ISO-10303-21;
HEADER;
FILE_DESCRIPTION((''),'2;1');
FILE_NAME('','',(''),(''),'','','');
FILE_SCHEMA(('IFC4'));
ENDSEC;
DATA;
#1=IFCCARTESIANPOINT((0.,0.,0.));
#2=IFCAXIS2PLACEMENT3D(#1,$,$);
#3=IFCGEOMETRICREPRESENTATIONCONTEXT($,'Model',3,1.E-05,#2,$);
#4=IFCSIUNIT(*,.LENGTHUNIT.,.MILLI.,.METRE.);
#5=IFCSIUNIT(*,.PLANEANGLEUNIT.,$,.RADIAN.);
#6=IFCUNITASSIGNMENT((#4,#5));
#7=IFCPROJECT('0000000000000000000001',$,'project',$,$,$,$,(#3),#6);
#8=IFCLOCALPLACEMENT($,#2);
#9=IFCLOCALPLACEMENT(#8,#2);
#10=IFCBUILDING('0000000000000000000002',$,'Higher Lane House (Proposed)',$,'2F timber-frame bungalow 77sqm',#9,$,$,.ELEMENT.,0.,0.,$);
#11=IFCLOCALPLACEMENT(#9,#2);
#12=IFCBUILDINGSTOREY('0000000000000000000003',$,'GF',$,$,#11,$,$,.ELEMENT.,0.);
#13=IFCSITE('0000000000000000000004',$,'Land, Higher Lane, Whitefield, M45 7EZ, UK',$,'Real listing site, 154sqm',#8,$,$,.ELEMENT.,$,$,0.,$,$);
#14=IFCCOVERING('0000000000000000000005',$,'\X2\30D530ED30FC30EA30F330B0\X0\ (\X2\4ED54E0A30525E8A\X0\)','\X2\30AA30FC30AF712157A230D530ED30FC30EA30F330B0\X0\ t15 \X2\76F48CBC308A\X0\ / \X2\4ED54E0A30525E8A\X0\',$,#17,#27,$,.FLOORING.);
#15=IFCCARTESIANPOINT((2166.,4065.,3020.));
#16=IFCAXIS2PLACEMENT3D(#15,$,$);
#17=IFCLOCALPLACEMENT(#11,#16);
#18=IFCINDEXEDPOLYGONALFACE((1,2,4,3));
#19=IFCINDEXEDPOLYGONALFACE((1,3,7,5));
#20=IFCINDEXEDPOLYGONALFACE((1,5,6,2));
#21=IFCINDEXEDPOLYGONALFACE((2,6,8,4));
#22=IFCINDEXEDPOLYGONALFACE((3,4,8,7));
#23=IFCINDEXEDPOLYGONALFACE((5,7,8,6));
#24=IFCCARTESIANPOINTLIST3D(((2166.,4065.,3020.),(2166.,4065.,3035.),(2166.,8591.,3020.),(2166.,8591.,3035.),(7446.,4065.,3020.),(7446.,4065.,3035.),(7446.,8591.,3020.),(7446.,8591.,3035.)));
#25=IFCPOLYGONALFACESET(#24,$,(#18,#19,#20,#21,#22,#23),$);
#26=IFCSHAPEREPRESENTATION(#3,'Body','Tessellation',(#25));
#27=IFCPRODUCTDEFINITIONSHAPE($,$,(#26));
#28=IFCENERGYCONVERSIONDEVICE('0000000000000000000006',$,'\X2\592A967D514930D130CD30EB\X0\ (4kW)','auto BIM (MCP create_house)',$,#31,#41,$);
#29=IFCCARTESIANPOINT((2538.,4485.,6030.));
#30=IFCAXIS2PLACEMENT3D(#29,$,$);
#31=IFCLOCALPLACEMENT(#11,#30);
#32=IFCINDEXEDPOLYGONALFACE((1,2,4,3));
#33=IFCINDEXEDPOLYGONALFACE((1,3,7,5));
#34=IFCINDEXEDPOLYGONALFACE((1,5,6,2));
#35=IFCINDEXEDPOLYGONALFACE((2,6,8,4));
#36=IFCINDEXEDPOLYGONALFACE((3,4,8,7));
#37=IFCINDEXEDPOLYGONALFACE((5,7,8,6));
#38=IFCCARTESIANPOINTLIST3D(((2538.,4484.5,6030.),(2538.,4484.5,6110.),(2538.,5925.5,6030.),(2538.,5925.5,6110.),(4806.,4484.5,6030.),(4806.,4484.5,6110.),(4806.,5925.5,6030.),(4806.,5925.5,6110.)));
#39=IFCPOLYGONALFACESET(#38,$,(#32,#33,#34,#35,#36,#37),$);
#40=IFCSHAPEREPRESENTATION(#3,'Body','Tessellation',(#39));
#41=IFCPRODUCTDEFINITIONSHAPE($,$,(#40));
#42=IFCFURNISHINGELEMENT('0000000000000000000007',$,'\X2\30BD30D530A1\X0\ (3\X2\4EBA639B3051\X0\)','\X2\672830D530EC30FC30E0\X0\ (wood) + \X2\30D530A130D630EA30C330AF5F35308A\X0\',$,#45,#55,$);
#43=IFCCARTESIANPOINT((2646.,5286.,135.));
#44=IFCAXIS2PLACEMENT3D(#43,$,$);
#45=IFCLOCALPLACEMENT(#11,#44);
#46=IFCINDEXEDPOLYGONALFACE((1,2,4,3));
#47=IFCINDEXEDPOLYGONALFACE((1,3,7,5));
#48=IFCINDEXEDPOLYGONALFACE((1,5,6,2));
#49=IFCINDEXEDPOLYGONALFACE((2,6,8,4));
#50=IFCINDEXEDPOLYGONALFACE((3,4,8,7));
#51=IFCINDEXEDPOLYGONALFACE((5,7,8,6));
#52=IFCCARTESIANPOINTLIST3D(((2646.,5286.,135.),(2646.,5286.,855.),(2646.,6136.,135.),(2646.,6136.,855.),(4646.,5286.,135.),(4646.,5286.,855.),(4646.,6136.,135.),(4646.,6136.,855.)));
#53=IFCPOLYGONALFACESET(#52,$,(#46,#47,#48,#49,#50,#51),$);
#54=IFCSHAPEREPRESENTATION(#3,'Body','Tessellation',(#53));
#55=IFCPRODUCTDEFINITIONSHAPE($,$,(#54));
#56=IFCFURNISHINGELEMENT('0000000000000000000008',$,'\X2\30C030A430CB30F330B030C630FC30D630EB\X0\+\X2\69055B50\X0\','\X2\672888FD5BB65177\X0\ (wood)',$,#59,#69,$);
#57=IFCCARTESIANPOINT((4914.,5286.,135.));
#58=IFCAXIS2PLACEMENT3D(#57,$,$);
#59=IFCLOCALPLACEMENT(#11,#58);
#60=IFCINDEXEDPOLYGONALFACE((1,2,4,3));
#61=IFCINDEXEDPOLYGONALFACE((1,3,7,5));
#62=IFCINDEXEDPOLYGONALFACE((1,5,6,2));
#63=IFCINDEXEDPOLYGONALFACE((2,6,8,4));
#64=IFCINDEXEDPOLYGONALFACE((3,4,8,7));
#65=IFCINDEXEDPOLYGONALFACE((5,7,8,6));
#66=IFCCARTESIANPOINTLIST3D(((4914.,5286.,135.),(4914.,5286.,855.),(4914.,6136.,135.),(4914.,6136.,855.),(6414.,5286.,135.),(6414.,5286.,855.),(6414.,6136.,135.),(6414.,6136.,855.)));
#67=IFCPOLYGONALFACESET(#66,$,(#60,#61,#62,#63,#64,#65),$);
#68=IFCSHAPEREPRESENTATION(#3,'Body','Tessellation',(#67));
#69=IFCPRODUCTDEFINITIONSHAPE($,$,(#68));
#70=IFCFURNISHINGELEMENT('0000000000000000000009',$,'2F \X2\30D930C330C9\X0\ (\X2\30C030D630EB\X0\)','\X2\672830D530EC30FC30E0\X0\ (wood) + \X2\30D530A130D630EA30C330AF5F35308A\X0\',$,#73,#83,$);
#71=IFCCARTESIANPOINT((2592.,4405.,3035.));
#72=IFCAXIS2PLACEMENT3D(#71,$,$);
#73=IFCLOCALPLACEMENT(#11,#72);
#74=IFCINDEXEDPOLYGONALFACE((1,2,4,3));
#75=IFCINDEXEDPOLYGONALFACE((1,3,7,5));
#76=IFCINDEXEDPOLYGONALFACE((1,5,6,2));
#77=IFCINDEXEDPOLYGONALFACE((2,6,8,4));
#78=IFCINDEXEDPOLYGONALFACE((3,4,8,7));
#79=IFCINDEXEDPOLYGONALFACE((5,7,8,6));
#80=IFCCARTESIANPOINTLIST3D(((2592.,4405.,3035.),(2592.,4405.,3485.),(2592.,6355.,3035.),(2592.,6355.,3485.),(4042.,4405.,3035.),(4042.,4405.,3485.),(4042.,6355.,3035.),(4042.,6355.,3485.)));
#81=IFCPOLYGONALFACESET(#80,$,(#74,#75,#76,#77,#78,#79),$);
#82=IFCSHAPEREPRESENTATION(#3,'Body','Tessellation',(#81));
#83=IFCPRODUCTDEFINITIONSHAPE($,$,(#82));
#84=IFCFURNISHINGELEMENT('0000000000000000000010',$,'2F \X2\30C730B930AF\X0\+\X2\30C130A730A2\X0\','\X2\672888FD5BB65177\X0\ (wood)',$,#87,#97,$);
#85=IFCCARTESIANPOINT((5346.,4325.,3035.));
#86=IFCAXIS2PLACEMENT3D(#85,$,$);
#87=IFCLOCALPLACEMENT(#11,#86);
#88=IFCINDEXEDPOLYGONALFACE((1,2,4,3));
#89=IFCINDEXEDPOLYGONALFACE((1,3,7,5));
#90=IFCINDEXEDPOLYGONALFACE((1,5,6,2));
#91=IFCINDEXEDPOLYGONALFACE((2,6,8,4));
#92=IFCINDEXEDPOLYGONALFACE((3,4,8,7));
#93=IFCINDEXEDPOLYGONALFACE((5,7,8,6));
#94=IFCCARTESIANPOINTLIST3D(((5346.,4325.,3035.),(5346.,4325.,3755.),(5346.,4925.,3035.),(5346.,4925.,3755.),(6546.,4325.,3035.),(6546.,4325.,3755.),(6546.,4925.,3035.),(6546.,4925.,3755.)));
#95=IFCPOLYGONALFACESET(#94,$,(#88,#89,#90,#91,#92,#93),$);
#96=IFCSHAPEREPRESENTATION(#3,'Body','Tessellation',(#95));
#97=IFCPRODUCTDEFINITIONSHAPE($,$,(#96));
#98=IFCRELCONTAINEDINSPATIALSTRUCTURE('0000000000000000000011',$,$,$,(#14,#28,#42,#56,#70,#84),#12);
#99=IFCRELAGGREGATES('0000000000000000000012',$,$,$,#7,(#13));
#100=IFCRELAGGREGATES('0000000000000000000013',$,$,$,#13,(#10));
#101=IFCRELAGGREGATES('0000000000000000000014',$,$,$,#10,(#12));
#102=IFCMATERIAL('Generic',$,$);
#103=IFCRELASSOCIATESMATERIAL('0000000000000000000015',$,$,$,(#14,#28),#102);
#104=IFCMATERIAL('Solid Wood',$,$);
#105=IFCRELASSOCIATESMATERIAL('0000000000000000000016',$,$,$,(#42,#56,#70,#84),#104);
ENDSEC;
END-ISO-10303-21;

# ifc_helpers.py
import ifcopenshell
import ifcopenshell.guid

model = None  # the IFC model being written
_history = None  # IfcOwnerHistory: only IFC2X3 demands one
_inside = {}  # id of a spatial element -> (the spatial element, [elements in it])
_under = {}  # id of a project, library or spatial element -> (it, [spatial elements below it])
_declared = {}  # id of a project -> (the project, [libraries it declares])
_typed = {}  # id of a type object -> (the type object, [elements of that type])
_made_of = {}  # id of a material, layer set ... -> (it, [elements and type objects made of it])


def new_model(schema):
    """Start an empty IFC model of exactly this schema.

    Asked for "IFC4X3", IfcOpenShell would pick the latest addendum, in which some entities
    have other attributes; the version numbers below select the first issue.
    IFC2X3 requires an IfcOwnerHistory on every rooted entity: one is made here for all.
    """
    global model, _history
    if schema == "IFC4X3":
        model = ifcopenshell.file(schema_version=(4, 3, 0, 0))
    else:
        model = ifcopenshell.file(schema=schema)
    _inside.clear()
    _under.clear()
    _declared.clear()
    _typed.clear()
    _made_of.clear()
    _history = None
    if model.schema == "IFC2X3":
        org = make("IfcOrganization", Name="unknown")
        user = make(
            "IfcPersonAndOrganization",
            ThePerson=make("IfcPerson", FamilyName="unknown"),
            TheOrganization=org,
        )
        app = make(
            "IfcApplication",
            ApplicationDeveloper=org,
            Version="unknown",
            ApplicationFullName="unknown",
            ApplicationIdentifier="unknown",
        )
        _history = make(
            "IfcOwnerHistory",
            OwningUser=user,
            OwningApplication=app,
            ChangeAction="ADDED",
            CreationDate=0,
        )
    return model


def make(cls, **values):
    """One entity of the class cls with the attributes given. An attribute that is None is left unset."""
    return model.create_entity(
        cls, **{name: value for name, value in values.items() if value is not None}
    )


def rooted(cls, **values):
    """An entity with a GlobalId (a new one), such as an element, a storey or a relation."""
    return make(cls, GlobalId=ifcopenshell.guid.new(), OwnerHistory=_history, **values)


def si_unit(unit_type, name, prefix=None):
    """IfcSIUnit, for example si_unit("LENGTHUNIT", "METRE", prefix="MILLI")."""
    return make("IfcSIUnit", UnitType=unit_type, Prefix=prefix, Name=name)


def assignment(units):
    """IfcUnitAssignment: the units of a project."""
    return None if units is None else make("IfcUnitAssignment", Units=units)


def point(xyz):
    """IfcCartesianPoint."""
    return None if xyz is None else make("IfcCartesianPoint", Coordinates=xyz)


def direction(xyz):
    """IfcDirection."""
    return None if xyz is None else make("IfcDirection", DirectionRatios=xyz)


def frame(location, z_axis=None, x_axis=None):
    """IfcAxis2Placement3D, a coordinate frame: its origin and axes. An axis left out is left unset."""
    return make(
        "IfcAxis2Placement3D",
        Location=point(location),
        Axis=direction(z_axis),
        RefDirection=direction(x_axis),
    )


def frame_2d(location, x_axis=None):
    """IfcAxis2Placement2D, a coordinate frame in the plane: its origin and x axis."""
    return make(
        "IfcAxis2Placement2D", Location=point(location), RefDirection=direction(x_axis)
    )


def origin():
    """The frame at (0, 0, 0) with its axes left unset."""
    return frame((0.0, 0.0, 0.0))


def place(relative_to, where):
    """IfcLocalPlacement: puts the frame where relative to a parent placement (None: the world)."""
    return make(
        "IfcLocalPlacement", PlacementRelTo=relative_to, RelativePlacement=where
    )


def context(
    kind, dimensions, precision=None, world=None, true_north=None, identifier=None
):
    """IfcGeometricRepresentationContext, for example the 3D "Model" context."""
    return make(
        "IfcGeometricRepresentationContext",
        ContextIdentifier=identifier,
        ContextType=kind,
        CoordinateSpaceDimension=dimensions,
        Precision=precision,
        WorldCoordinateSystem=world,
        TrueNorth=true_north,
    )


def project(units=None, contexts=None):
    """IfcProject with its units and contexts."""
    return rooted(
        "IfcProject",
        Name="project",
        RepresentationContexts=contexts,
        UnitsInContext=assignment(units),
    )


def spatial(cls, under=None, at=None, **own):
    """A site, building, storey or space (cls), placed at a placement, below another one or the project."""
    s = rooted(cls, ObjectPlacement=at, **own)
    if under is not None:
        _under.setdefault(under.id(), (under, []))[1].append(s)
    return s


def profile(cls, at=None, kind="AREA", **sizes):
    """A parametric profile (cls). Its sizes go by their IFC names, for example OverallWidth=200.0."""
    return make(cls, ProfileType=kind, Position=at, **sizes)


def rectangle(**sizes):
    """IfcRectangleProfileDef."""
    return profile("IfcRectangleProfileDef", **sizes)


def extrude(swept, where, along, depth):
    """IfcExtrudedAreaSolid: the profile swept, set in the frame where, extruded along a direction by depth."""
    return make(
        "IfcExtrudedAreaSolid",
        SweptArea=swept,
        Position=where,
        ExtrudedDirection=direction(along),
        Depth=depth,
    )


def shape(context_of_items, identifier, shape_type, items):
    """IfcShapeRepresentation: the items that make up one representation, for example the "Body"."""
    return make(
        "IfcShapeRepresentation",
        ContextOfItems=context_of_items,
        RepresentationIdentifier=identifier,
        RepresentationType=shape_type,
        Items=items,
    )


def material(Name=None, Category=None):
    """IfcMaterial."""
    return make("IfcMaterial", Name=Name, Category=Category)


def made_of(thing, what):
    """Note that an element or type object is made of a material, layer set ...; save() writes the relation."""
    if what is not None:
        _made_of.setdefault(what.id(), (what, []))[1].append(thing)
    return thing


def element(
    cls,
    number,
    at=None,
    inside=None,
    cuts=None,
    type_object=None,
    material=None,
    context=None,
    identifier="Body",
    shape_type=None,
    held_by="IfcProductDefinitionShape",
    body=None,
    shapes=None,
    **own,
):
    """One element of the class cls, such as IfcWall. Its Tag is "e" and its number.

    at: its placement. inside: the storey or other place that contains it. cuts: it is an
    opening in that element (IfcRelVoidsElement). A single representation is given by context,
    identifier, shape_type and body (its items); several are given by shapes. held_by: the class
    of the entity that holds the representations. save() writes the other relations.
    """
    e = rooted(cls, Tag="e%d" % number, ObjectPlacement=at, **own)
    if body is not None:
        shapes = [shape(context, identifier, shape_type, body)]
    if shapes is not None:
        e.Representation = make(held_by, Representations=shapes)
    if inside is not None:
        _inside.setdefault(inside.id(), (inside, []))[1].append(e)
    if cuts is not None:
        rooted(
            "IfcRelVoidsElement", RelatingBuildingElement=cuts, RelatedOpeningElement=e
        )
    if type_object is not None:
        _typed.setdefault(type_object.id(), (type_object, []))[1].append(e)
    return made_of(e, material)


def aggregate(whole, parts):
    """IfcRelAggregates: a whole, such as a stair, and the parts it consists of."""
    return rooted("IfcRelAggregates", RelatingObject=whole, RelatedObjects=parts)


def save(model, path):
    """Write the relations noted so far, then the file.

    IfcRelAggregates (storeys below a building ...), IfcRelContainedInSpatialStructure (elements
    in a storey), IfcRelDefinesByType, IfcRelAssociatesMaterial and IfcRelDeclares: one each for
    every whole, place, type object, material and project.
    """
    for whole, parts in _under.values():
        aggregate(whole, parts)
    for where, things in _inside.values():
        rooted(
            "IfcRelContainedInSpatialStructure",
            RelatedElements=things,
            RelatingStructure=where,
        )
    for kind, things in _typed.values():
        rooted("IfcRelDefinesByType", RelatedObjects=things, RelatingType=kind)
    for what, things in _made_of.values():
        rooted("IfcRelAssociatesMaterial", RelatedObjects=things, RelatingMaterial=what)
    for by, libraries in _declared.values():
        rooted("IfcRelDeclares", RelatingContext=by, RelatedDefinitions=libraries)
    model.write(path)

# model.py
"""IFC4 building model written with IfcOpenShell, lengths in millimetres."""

from ifc_helpers import new_model, si_unit, frame, frame_2d, origin, place, context, project, spatial, rectangle, extrude, material, element, save


model = new_model("IFC4")

# Units and contexts
model_context = context("Model", 3, precision=1e-05, world=origin())
ifc_project = project(units=[si_unit("LENGTHUNIT", "METRE", prefix="MILLI"), si_unit("PLANEANGLEUNIT", "RADIAN")], contexts=[model_context])

# Site, building, storey
site_placement = place(None, origin())
site = spatial("IfcSite", under=ifc_project, at=site_placement, Name="Land, Higher Lane, Whitefield, M45 7EZ, UK", ObjectType="Real listing site, 154sqm", CompositionType="ELEMENT", RefElevation=0.0)
building_placement = place(site_placement, origin())
building = spatial("IfcBuilding", under=site, at=building_placement, Name="Higher Lane House (Proposed)", ObjectType="2F timber-frame bungalow 77sqm", CompositionType="ELEMENT", ElevationOfRefHeight=0.0, ElevationOfTerrain=0.0)
storey_placement = place(building_placement, origin())
storey = spatial("IfcBuildingStorey", under=building, at=storey_placement, Name="GF", CompositionType="ELEMENT", Elevation=0.0)

# Shared definitions
ifc_material_1 = material(Name="Solid Wood")

# Covering
ifc_material_2 = material(Name="Generic")
covering_placement = place(storey_placement, frame((2166.0, 4065.0, 3020.0)))
element("IfcCovering", 1, at=covering_placement, inside=storey, material=ifc_material_2, Name="フローリング (仕上げ床)", Description="オーク無垢フローリング t15 直貼り / 仕上げ床", PredefinedType="FLOORING", context=model_context, shape_type="SweptSolid", body=[
    extrude(rectangle(XDim=5280.0, YDim=4526.0, at=frame_2d((2640.0, 2263.0))), frame((2166.0, 4065.0, 3020.0)), (0.0, 0.0, 1.0), 15.0),
])

# Energy conversion device
energy_conversion_device_placement = place(storey_placement, frame((2538.0, 4485.0, 6030.0)))
element("IfcEnergyConversionDevice", 2, at=energy_conversion_device_placement, inside=storey, material=ifc_material_2, Name="太陽光パネル (4kW)", Description="auto BIM (MCP create_house)", context=model_context, shape_type="SweptSolid", body=[
    extrude(rectangle(XDim=2268.0, YDim=1441.0, at=frame_2d((1134.0, 720.0))), frame((2538.0, 4485.0, 6030.0)), (0.0, 0.0, 1.0), 80.0),
])

# Furnishing elements
furnishing_1_placement = place(storey_placement, frame((2646.0, 5286.0, 135.0)))
element("IfcFurnishingElement", 3, at=furnishing_1_placement, inside=storey, material=ifc_material_1, Name="ソファ (3人掛け)", Description="木フレーム (wood) + ファブリック張り", context=model_context, shape_type="SweptSolid", body=[
    extrude(rectangle(XDim=2000.0, YDim=850.0, at=frame_2d((1000.0, 425.0))), frame((2646.0, 5286.0, 135.0)), (0.0, 0.0, 1.0), 720.0),
])
furnishing_2_placement = place(storey_placement, frame((4914.0, 5286.0, 135.0)))
element("IfcFurnishingElement", 4, at=furnishing_2_placement, inside=storey, material=ifc_material_1, Name="ダイニングテーブル+椅子", Description="木製家具 (wood)", context=model_context, shape_type="SweptSolid", body=[
    extrude(rectangle(XDim=1500.0, YDim=850.0, at=frame_2d((750.0, 425.0))), frame((4914.0, 5286.0, 135.0)), (0.0, 0.0, 1.0), 720.0),
])
furnishing_3_placement = place(storey_placement, frame((2592.0, 4405.0, 3035.0)))
element("IfcFurnishingElement", 5, at=furnishing_3_placement, inside=storey, material=ifc_material_1, Name="2F ベッド (ダブル)", Description="木フレーム (wood) + ファブリック張り", context=model_context, shape_type="SweptSolid", body=[
    extrude(rectangle(XDim=1450.0, YDim=1950.0, at=frame_2d((725.0, 975.0))), frame((2592.0, 4405.0, 3035.0)), (0.0, 0.0, 1.0), 450.0),
])
furnishing_4_placement = place(storey_placement, frame((5346.0, 4325.0, 3035.0)))
element("IfcFurnishingElement", 6, at=furnishing_4_placement, inside=storey, material=ifc_material_1, Name="2F デスク+チェア", Description="木製家具 (wood)", context=model_context, shape_type="SweptSolid", body=[
    extrude(rectangle(XDim=1200.0, YDim=600.0, at=frame_2d((600.0, 300.0))), frame((5346.0, 4325.0, 3035.0)), (0.0, 0.0, 1.0), 720.0),
])

save(model, "model.ifc")
